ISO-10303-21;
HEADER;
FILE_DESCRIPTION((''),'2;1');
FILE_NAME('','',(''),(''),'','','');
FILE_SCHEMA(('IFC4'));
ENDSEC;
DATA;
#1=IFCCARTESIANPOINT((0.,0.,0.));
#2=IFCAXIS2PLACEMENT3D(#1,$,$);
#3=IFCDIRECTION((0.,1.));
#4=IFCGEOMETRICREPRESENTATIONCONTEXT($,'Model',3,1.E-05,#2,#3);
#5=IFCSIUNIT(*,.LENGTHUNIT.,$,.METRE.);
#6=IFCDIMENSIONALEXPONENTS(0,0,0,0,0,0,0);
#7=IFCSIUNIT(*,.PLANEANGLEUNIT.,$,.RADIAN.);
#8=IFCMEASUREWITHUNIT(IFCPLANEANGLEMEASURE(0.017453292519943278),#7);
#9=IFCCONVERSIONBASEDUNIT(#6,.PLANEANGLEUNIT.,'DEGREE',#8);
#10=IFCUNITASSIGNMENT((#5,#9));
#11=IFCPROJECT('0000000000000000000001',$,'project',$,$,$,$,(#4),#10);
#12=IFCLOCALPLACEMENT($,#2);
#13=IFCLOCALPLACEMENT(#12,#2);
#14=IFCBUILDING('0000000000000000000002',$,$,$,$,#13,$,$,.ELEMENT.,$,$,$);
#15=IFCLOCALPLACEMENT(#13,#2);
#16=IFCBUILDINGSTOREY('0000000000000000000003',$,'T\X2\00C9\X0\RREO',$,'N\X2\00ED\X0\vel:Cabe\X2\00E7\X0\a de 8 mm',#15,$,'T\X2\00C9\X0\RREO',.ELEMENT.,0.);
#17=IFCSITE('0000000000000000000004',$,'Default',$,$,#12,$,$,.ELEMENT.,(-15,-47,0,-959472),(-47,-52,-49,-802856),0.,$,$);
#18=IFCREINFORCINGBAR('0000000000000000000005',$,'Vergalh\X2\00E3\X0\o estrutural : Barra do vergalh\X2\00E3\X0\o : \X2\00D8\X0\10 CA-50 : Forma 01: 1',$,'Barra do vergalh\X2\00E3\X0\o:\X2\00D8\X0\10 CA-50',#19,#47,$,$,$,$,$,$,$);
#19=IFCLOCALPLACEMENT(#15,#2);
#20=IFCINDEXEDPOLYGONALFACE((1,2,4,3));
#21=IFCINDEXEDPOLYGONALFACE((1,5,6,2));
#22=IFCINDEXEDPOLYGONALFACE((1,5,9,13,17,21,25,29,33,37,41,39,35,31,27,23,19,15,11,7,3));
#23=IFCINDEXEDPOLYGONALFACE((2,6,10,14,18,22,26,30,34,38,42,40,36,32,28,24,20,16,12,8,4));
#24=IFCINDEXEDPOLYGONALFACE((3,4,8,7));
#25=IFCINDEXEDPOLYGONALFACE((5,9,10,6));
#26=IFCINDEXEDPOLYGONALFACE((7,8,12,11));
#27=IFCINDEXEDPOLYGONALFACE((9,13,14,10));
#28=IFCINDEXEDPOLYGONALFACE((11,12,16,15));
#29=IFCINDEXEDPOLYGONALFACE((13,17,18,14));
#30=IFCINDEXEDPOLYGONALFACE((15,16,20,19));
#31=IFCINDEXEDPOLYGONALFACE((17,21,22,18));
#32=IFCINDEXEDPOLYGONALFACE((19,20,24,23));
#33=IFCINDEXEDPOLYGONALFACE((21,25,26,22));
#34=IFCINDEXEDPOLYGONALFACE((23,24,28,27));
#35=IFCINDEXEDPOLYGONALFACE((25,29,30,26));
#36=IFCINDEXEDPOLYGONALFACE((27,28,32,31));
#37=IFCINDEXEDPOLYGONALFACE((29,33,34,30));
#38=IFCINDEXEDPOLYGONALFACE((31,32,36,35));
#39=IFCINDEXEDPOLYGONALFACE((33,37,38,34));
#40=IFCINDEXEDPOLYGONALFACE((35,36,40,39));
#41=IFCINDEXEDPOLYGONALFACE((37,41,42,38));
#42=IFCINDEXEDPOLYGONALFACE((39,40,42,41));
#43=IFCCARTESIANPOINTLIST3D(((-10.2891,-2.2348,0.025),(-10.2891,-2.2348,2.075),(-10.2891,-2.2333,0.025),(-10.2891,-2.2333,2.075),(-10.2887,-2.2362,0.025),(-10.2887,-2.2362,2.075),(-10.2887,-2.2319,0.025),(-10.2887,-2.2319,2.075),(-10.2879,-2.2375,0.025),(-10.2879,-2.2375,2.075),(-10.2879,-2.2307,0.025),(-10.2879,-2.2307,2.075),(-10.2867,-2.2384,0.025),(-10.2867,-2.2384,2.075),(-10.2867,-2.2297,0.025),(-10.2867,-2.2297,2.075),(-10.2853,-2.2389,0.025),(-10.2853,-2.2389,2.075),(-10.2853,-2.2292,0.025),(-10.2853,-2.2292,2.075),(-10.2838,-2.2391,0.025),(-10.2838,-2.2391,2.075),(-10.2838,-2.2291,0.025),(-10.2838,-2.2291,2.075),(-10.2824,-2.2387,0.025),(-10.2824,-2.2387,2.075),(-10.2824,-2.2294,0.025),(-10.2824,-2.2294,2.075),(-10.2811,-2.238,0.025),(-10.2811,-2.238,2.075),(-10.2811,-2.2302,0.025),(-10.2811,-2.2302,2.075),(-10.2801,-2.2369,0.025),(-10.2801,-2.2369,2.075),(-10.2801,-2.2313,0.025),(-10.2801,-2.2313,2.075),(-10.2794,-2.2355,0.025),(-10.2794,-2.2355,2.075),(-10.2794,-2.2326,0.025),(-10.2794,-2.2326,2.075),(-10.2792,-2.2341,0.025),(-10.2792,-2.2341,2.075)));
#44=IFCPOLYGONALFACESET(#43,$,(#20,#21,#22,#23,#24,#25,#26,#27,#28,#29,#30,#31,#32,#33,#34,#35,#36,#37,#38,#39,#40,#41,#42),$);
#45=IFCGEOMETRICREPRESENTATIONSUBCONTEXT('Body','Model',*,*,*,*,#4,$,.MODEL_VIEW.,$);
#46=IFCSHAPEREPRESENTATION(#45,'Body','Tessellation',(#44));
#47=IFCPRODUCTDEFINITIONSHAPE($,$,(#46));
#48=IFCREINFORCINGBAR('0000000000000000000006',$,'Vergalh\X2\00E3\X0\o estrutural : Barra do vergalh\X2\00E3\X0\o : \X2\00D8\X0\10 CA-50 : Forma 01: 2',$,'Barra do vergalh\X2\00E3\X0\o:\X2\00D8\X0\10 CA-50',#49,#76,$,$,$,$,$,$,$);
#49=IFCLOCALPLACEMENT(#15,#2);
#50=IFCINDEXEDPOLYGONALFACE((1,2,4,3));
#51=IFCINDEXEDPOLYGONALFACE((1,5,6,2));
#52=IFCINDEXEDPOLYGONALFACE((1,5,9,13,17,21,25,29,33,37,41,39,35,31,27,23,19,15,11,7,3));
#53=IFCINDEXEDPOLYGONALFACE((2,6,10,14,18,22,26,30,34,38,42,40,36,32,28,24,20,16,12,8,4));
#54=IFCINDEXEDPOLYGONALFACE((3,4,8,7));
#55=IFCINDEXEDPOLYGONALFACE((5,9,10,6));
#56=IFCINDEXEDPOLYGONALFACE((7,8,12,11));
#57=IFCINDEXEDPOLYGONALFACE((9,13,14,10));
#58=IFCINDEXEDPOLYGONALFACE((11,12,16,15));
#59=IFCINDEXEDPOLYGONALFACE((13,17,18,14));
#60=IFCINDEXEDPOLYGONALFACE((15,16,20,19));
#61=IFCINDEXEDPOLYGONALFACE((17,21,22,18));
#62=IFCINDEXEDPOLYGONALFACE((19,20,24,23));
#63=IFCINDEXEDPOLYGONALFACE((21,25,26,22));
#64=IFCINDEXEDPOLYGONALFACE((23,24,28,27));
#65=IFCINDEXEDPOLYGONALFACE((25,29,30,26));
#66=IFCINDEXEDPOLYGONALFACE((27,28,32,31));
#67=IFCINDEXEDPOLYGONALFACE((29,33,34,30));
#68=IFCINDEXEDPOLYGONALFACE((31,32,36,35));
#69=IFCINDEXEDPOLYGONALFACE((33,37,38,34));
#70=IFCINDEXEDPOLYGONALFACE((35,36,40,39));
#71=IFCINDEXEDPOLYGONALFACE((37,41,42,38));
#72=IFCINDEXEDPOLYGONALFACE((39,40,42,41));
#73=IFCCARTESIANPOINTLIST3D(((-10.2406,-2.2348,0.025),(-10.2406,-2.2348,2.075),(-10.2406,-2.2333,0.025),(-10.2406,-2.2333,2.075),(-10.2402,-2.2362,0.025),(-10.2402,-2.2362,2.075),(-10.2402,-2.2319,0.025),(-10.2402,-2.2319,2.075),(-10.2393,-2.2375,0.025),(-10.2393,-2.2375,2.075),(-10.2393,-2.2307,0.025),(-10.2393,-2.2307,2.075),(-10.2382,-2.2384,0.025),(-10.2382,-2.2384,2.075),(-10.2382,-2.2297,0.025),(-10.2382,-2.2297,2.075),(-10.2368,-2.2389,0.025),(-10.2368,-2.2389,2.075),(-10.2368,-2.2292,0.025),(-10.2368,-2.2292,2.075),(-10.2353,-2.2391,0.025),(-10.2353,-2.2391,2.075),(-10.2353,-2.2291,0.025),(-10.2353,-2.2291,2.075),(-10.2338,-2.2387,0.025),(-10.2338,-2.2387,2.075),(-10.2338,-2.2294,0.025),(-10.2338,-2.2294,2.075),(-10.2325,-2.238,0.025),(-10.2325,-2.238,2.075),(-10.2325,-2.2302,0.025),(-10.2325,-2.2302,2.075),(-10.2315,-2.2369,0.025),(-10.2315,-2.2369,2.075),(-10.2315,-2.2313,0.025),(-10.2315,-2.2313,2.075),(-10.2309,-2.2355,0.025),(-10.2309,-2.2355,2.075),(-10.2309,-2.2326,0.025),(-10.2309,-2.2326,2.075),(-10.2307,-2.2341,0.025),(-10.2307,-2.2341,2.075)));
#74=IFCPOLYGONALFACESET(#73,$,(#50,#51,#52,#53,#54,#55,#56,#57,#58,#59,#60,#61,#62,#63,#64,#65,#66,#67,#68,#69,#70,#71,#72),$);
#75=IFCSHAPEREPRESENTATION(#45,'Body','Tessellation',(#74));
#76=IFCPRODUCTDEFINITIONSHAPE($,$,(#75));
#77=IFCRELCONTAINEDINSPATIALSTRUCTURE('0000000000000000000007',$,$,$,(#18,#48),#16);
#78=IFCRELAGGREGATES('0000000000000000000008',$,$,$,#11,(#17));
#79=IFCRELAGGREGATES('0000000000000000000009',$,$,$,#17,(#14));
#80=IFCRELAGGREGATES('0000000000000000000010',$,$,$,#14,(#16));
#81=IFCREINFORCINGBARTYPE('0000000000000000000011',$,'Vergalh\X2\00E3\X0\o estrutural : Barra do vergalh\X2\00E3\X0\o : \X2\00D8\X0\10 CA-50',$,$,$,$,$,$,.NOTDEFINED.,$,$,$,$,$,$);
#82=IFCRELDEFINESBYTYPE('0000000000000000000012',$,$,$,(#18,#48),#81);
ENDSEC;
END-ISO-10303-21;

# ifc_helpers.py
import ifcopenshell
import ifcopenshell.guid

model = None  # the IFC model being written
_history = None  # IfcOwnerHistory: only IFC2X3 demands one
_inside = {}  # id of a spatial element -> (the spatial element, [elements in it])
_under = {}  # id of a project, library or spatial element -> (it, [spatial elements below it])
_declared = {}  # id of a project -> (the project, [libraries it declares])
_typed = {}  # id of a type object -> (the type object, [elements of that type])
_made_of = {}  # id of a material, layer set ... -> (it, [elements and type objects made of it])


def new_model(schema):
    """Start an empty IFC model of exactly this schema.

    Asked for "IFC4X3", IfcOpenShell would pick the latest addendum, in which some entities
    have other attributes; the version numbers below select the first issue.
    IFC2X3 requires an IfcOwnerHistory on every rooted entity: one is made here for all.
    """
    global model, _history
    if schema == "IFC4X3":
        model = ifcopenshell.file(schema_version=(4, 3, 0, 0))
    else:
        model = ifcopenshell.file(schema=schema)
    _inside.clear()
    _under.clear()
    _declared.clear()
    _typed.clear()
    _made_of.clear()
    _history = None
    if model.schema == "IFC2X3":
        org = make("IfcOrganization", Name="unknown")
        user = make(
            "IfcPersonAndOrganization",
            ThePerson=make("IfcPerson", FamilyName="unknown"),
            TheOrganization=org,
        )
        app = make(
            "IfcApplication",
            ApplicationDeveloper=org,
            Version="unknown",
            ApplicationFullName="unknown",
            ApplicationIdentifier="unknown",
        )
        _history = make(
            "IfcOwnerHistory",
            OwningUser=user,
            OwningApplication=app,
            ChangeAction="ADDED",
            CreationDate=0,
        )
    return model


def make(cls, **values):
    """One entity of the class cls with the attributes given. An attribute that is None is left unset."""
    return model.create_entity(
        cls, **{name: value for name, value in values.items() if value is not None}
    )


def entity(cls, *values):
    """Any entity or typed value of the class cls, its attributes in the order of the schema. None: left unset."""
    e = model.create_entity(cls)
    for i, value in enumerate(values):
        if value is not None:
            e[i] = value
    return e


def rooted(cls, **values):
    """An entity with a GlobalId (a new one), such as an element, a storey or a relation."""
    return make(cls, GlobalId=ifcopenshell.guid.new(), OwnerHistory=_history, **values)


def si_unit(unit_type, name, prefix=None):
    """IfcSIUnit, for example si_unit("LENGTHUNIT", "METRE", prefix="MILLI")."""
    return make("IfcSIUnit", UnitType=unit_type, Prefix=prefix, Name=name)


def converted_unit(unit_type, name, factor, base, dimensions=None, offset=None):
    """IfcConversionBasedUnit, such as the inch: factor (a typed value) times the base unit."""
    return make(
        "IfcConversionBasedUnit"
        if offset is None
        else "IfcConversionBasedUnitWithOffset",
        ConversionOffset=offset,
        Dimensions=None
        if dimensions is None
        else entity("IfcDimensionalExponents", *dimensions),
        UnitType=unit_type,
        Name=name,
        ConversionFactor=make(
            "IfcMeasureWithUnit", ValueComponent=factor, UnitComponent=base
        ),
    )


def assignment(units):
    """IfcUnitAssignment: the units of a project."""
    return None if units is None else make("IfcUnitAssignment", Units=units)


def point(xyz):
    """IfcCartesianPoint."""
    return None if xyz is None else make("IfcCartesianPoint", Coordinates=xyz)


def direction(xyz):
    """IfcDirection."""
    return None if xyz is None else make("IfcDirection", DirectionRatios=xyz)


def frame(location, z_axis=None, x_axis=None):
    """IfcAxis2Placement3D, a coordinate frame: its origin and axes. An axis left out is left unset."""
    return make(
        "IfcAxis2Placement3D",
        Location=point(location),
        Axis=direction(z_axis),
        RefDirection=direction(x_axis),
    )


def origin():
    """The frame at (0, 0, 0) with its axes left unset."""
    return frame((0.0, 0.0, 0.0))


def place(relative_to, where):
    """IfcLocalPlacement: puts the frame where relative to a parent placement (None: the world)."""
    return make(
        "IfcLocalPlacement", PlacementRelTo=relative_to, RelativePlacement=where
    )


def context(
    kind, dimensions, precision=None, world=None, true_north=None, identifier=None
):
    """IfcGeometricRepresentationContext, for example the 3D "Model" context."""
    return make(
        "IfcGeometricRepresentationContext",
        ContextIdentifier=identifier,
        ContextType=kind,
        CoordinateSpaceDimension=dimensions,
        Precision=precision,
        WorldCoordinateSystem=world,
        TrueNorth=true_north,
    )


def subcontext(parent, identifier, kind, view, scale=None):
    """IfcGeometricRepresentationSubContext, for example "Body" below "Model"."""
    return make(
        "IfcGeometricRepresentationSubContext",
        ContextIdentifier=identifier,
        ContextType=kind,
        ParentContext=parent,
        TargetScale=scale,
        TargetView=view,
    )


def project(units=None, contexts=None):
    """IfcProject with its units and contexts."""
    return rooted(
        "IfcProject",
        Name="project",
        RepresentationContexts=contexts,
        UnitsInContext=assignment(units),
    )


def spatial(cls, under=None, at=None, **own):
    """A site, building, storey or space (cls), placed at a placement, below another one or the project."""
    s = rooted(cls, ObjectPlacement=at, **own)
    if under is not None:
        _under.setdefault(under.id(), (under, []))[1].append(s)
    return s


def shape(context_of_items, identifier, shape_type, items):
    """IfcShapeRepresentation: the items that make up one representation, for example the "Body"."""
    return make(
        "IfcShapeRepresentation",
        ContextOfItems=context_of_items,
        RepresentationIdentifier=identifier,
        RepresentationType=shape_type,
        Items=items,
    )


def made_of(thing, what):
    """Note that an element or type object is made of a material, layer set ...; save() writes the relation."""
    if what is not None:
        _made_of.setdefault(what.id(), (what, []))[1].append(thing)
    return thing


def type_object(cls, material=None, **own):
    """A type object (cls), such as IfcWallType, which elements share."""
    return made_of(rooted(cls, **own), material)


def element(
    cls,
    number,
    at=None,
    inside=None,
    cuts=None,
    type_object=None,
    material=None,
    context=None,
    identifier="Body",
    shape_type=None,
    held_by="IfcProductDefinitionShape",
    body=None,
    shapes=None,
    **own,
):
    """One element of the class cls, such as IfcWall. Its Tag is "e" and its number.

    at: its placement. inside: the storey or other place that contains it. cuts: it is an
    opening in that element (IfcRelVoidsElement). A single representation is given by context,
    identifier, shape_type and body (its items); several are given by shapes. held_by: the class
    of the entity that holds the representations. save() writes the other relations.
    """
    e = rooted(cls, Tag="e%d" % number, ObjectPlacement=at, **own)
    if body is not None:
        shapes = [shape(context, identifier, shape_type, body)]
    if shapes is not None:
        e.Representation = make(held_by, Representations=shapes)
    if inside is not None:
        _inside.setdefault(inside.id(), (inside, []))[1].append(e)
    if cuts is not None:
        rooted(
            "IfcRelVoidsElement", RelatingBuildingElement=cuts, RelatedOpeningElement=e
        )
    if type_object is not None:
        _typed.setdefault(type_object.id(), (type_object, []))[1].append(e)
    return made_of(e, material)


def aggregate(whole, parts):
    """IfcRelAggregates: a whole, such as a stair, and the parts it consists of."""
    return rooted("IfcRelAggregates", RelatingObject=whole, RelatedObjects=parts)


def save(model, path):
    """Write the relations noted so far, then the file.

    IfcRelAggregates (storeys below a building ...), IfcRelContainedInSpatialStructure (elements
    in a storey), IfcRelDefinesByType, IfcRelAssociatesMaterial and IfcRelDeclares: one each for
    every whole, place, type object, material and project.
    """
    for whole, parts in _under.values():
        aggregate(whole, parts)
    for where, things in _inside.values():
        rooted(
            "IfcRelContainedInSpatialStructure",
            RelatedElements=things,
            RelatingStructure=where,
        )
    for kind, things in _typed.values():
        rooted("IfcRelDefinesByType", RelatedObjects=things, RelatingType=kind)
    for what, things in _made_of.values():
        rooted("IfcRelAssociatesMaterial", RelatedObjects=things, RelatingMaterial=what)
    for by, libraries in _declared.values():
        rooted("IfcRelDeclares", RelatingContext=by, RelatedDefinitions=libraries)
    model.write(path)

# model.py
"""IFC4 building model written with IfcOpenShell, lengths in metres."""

from ifc_helpers import new_model, entity, si_unit, converted_unit, direction, origin, place, context, subcontext, project, spatial, type_object, element, save


model = new_model("IFC4")

# Units and contexts
model_context = context("Model", 3, precision=1e-05, world=origin(), true_north=direction((0.0, 1.0)))
body_context = subcontext(model_context, "Body", "Model", "MODEL_VIEW")
ifc_project = project(units=[si_unit("LENGTHUNIT", "METRE"), converted_unit("PLANEANGLEUNIT", "DEGREE", entity("IfcPlaneAngleMeasure", 0.017453292519943278), si_unit("PLANEANGLEUNIT", "RADIAN"), dimensions=[0, 0, 0, 0, 0, 0, 0])], contexts=[model_context])

# Site, building, storey
site_placement = place(None, origin())
site = spatial("IfcSite", under=ifc_project, at=site_placement, Name="Default", CompositionType="ELEMENT", RefLatitude=(-15, -47, 0, -959472), RefLongitude=(-47, -52, -49, -802856), RefElevation=0.0)
building_placement = place(site_placement, origin())
building = spatial("IfcBuilding", under=site, at=building_placement, CompositionType="ELEMENT")
storey_placement = place(building_placement, origin())
storey = spatial("IfcBuildingStorey", under=building, at=storey_placement, Name="TÉRREO", ObjectType="Nível:Cabeça de 8 mm", LongName="TÉRREO", CompositionType="ELEMENT", Elevation=0.0)

# Reinforcing bars
reinforcing_bar_type_1 = type_object("IfcReinforcingBarType", Name="Vergalhão estrutural : Barra do vergalhão : Ø10 CA-50", PredefinedType="NOTDEFINED")
reinforcing_bar_1_placement = place(storey_placement, origin())
element("IfcReinforcingBar", 1, at=reinforcing_bar_1_placement, inside=storey, type_object=reinforcing_bar_type_1, Name="Vergalhão estrutural : Barra do vergalhão : Ø10 CA-50 : Forma 01: 1", ObjectType="Barra do vergalhão:Ø10 CA-50", context=body_context, shape_type="AdvancedSweptSolid", body=[
    entity("IfcSweptDiskSolid", entity("IfcIndexedPolyCurve", entity("IfcCartesianPointList3D", [[-10.2842, -2.2341, 0.025], [-10.2842, -2.2341, 2.075]]), None, False), 0.005, None, 0.0, 1.0),
])
reinforcing_bar_2_placement = place(storey_placement, origin())
element("IfcReinforcingBar", 2, at=reinforcing_bar_2_placement, inside=storey, type_object=reinforcing_bar_type_1, Name="Vergalhão estrutural : Barra do vergalhão : Ø10 CA-50 : Forma 01: 2", ObjectType="Barra do vergalhão:Ø10 CA-50", context=body_context, shape_type="AdvancedSweptSolid", body=[
    entity("IfcSweptDiskSolid", entity("IfcIndexedPolyCurve", entity("IfcCartesianPointList3D", [[-10.2357, -2.2341, 0.025], [-10.2357, -2.2341, 2.075]]), None, False), 0.005, None, 0.0, 1.0),
])

save(model, "model.ifc")
